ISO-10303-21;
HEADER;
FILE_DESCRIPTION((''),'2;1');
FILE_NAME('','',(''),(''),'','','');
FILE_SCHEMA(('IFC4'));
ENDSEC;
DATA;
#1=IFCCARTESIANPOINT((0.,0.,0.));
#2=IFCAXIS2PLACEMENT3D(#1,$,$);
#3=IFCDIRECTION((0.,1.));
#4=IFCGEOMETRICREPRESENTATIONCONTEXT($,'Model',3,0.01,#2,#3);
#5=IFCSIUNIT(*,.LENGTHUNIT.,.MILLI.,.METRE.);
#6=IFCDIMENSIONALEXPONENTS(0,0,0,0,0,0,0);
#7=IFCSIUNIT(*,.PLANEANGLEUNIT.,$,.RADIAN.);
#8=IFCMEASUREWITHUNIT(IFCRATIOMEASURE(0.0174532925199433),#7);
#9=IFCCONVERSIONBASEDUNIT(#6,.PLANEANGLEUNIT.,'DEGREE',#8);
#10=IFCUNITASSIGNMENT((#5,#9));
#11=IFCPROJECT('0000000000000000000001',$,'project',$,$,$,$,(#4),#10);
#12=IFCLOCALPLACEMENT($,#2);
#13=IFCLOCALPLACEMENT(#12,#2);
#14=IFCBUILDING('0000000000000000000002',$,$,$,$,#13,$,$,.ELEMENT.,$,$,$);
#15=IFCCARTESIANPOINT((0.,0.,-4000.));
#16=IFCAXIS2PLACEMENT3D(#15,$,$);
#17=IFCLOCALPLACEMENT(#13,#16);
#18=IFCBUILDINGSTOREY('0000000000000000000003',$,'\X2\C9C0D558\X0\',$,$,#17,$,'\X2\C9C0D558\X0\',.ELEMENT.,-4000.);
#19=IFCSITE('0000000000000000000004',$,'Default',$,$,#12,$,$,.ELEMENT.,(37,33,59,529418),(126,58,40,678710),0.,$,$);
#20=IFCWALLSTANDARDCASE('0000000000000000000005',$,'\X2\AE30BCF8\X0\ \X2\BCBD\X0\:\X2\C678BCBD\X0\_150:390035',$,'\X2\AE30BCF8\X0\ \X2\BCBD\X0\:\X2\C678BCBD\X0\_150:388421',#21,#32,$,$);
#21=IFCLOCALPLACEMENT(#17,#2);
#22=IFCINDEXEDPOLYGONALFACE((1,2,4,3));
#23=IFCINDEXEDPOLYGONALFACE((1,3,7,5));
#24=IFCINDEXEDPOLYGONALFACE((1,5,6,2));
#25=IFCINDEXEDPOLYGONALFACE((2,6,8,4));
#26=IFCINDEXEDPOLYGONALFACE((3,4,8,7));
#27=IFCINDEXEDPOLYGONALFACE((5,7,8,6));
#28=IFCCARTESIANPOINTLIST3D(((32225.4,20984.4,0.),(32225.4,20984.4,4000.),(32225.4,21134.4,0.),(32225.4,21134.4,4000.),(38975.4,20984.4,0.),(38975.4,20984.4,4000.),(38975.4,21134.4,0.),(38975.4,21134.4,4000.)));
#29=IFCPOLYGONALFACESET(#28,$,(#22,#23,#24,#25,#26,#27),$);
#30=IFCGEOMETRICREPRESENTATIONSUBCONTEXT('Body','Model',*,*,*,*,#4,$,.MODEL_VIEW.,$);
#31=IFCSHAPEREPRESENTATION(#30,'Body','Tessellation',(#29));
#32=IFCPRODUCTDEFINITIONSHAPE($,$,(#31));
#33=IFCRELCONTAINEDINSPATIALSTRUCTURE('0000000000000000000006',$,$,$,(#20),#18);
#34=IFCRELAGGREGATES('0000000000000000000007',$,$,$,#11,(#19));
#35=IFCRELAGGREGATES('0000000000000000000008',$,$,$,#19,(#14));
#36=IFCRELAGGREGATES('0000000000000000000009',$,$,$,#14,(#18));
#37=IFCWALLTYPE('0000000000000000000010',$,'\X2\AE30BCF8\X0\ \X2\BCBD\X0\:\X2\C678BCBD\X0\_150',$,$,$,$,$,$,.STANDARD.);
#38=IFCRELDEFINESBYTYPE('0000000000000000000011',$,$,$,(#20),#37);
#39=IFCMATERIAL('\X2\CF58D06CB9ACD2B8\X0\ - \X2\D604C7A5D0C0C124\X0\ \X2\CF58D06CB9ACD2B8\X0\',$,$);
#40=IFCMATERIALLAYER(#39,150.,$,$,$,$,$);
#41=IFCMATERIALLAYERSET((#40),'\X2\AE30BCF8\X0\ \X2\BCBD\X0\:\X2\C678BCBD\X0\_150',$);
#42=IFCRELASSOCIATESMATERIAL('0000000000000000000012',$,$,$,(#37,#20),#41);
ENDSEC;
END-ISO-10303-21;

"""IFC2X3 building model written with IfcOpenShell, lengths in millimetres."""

from ifc_helpers import new_model, entity, si_unit, converted_unit, direction, frame, frame_2d, origin, place, context, subcontext, project, spatial, rectangle, extrude, material, layer, layer_set, layer_usage, type_object, element, save


model = new_model("IFC2X3")

# Units and contexts
model_context = context("Model", 3, precision=0.01, world=origin(), true_north=direction((0.0, 1.0)))
body_context = subcontext(model_context, "Body", "Model", "MODEL_VIEW")
ifc_project = project(units=[si_unit("LENGTHUNIT", "METRE", prefix="MILLI"), converted_unit("PLANEANGLEUNIT", "DEGREE", entity("IfcRatioMeasure", 0.0174532925199433), si_unit("PLANEANGLEUNIT", "RADIAN"), dimensions=[0, 0, 0, 0, 0, 0, 0])], contexts=[model_context])

# Site, building, storey
site_placement = place(None, origin())
site = spatial("IfcSite", under=ifc_project, at=site_placement, Name="Default", CompositionType="ELEMENT", RefLatitude=(37, 33, 59, 529418), RefLongitude=(126, 58, 40, 678710), RefElevation=0.0)
building_placement = place(site_placement, origin())
building = spatial("IfcBuilding", under=site, at=building_placement, CompositionType="ELEMENT")
storey_placement = place(building_placement, frame((0.0, 0.0, -4000.0)))
storey = spatial("IfcBuildingStorey", under=building, at=storey_placement, Name="지하", LongName="지하", CompositionType="ELEMENT", Elevation=-4000.0)

# Shared definitions
ifc_material_1 = material(Name="콘크리트 - 현장타설 콘크리트")

# Wall
ifc_layer_1 = layer(ifc_material_1, 150.0)
ifc_layer_set_1 = layer_set([ifc_layer_1], Name="기본 벽:외벽_150")
wall_type_1 = type_object("IfcWallType", Name="기본 벽:외벽_150", PredefinedType="STANDARD", material=ifc_layer_set_1)
ifc_layer_usage_1 = layer_usage(ifc_layer_set_1, "AXIS2", "NEGATIVE", 75.0)
wall_1_placement = place(storey_placement, frame((38975.4, 21059.4, 0.0), z_axis=(0.0, 0.0, 1.0), x_axis=(-1.0, 0.0, 0.0)))
element("IfcWallStandardCase", 1, at=wall_1_placement, inside=storey, type_object=wall_type_1, material=ifc_layer_usage_1, Name="기본 벽:외벽_150:390035", ObjectType="기본 벽:외벽_150:388421", context=body_context, shape_type="SweptSolid", body=[
    extrude(rectangle(XDim=6750.0, YDim=150.0, at=frame_2d((3375.0, 0.0), x_axis=(-1.0, 0.0))), origin(), (0.0, 0.0, 1.0), 4000.0),
])

save(model, "model.ifc")
